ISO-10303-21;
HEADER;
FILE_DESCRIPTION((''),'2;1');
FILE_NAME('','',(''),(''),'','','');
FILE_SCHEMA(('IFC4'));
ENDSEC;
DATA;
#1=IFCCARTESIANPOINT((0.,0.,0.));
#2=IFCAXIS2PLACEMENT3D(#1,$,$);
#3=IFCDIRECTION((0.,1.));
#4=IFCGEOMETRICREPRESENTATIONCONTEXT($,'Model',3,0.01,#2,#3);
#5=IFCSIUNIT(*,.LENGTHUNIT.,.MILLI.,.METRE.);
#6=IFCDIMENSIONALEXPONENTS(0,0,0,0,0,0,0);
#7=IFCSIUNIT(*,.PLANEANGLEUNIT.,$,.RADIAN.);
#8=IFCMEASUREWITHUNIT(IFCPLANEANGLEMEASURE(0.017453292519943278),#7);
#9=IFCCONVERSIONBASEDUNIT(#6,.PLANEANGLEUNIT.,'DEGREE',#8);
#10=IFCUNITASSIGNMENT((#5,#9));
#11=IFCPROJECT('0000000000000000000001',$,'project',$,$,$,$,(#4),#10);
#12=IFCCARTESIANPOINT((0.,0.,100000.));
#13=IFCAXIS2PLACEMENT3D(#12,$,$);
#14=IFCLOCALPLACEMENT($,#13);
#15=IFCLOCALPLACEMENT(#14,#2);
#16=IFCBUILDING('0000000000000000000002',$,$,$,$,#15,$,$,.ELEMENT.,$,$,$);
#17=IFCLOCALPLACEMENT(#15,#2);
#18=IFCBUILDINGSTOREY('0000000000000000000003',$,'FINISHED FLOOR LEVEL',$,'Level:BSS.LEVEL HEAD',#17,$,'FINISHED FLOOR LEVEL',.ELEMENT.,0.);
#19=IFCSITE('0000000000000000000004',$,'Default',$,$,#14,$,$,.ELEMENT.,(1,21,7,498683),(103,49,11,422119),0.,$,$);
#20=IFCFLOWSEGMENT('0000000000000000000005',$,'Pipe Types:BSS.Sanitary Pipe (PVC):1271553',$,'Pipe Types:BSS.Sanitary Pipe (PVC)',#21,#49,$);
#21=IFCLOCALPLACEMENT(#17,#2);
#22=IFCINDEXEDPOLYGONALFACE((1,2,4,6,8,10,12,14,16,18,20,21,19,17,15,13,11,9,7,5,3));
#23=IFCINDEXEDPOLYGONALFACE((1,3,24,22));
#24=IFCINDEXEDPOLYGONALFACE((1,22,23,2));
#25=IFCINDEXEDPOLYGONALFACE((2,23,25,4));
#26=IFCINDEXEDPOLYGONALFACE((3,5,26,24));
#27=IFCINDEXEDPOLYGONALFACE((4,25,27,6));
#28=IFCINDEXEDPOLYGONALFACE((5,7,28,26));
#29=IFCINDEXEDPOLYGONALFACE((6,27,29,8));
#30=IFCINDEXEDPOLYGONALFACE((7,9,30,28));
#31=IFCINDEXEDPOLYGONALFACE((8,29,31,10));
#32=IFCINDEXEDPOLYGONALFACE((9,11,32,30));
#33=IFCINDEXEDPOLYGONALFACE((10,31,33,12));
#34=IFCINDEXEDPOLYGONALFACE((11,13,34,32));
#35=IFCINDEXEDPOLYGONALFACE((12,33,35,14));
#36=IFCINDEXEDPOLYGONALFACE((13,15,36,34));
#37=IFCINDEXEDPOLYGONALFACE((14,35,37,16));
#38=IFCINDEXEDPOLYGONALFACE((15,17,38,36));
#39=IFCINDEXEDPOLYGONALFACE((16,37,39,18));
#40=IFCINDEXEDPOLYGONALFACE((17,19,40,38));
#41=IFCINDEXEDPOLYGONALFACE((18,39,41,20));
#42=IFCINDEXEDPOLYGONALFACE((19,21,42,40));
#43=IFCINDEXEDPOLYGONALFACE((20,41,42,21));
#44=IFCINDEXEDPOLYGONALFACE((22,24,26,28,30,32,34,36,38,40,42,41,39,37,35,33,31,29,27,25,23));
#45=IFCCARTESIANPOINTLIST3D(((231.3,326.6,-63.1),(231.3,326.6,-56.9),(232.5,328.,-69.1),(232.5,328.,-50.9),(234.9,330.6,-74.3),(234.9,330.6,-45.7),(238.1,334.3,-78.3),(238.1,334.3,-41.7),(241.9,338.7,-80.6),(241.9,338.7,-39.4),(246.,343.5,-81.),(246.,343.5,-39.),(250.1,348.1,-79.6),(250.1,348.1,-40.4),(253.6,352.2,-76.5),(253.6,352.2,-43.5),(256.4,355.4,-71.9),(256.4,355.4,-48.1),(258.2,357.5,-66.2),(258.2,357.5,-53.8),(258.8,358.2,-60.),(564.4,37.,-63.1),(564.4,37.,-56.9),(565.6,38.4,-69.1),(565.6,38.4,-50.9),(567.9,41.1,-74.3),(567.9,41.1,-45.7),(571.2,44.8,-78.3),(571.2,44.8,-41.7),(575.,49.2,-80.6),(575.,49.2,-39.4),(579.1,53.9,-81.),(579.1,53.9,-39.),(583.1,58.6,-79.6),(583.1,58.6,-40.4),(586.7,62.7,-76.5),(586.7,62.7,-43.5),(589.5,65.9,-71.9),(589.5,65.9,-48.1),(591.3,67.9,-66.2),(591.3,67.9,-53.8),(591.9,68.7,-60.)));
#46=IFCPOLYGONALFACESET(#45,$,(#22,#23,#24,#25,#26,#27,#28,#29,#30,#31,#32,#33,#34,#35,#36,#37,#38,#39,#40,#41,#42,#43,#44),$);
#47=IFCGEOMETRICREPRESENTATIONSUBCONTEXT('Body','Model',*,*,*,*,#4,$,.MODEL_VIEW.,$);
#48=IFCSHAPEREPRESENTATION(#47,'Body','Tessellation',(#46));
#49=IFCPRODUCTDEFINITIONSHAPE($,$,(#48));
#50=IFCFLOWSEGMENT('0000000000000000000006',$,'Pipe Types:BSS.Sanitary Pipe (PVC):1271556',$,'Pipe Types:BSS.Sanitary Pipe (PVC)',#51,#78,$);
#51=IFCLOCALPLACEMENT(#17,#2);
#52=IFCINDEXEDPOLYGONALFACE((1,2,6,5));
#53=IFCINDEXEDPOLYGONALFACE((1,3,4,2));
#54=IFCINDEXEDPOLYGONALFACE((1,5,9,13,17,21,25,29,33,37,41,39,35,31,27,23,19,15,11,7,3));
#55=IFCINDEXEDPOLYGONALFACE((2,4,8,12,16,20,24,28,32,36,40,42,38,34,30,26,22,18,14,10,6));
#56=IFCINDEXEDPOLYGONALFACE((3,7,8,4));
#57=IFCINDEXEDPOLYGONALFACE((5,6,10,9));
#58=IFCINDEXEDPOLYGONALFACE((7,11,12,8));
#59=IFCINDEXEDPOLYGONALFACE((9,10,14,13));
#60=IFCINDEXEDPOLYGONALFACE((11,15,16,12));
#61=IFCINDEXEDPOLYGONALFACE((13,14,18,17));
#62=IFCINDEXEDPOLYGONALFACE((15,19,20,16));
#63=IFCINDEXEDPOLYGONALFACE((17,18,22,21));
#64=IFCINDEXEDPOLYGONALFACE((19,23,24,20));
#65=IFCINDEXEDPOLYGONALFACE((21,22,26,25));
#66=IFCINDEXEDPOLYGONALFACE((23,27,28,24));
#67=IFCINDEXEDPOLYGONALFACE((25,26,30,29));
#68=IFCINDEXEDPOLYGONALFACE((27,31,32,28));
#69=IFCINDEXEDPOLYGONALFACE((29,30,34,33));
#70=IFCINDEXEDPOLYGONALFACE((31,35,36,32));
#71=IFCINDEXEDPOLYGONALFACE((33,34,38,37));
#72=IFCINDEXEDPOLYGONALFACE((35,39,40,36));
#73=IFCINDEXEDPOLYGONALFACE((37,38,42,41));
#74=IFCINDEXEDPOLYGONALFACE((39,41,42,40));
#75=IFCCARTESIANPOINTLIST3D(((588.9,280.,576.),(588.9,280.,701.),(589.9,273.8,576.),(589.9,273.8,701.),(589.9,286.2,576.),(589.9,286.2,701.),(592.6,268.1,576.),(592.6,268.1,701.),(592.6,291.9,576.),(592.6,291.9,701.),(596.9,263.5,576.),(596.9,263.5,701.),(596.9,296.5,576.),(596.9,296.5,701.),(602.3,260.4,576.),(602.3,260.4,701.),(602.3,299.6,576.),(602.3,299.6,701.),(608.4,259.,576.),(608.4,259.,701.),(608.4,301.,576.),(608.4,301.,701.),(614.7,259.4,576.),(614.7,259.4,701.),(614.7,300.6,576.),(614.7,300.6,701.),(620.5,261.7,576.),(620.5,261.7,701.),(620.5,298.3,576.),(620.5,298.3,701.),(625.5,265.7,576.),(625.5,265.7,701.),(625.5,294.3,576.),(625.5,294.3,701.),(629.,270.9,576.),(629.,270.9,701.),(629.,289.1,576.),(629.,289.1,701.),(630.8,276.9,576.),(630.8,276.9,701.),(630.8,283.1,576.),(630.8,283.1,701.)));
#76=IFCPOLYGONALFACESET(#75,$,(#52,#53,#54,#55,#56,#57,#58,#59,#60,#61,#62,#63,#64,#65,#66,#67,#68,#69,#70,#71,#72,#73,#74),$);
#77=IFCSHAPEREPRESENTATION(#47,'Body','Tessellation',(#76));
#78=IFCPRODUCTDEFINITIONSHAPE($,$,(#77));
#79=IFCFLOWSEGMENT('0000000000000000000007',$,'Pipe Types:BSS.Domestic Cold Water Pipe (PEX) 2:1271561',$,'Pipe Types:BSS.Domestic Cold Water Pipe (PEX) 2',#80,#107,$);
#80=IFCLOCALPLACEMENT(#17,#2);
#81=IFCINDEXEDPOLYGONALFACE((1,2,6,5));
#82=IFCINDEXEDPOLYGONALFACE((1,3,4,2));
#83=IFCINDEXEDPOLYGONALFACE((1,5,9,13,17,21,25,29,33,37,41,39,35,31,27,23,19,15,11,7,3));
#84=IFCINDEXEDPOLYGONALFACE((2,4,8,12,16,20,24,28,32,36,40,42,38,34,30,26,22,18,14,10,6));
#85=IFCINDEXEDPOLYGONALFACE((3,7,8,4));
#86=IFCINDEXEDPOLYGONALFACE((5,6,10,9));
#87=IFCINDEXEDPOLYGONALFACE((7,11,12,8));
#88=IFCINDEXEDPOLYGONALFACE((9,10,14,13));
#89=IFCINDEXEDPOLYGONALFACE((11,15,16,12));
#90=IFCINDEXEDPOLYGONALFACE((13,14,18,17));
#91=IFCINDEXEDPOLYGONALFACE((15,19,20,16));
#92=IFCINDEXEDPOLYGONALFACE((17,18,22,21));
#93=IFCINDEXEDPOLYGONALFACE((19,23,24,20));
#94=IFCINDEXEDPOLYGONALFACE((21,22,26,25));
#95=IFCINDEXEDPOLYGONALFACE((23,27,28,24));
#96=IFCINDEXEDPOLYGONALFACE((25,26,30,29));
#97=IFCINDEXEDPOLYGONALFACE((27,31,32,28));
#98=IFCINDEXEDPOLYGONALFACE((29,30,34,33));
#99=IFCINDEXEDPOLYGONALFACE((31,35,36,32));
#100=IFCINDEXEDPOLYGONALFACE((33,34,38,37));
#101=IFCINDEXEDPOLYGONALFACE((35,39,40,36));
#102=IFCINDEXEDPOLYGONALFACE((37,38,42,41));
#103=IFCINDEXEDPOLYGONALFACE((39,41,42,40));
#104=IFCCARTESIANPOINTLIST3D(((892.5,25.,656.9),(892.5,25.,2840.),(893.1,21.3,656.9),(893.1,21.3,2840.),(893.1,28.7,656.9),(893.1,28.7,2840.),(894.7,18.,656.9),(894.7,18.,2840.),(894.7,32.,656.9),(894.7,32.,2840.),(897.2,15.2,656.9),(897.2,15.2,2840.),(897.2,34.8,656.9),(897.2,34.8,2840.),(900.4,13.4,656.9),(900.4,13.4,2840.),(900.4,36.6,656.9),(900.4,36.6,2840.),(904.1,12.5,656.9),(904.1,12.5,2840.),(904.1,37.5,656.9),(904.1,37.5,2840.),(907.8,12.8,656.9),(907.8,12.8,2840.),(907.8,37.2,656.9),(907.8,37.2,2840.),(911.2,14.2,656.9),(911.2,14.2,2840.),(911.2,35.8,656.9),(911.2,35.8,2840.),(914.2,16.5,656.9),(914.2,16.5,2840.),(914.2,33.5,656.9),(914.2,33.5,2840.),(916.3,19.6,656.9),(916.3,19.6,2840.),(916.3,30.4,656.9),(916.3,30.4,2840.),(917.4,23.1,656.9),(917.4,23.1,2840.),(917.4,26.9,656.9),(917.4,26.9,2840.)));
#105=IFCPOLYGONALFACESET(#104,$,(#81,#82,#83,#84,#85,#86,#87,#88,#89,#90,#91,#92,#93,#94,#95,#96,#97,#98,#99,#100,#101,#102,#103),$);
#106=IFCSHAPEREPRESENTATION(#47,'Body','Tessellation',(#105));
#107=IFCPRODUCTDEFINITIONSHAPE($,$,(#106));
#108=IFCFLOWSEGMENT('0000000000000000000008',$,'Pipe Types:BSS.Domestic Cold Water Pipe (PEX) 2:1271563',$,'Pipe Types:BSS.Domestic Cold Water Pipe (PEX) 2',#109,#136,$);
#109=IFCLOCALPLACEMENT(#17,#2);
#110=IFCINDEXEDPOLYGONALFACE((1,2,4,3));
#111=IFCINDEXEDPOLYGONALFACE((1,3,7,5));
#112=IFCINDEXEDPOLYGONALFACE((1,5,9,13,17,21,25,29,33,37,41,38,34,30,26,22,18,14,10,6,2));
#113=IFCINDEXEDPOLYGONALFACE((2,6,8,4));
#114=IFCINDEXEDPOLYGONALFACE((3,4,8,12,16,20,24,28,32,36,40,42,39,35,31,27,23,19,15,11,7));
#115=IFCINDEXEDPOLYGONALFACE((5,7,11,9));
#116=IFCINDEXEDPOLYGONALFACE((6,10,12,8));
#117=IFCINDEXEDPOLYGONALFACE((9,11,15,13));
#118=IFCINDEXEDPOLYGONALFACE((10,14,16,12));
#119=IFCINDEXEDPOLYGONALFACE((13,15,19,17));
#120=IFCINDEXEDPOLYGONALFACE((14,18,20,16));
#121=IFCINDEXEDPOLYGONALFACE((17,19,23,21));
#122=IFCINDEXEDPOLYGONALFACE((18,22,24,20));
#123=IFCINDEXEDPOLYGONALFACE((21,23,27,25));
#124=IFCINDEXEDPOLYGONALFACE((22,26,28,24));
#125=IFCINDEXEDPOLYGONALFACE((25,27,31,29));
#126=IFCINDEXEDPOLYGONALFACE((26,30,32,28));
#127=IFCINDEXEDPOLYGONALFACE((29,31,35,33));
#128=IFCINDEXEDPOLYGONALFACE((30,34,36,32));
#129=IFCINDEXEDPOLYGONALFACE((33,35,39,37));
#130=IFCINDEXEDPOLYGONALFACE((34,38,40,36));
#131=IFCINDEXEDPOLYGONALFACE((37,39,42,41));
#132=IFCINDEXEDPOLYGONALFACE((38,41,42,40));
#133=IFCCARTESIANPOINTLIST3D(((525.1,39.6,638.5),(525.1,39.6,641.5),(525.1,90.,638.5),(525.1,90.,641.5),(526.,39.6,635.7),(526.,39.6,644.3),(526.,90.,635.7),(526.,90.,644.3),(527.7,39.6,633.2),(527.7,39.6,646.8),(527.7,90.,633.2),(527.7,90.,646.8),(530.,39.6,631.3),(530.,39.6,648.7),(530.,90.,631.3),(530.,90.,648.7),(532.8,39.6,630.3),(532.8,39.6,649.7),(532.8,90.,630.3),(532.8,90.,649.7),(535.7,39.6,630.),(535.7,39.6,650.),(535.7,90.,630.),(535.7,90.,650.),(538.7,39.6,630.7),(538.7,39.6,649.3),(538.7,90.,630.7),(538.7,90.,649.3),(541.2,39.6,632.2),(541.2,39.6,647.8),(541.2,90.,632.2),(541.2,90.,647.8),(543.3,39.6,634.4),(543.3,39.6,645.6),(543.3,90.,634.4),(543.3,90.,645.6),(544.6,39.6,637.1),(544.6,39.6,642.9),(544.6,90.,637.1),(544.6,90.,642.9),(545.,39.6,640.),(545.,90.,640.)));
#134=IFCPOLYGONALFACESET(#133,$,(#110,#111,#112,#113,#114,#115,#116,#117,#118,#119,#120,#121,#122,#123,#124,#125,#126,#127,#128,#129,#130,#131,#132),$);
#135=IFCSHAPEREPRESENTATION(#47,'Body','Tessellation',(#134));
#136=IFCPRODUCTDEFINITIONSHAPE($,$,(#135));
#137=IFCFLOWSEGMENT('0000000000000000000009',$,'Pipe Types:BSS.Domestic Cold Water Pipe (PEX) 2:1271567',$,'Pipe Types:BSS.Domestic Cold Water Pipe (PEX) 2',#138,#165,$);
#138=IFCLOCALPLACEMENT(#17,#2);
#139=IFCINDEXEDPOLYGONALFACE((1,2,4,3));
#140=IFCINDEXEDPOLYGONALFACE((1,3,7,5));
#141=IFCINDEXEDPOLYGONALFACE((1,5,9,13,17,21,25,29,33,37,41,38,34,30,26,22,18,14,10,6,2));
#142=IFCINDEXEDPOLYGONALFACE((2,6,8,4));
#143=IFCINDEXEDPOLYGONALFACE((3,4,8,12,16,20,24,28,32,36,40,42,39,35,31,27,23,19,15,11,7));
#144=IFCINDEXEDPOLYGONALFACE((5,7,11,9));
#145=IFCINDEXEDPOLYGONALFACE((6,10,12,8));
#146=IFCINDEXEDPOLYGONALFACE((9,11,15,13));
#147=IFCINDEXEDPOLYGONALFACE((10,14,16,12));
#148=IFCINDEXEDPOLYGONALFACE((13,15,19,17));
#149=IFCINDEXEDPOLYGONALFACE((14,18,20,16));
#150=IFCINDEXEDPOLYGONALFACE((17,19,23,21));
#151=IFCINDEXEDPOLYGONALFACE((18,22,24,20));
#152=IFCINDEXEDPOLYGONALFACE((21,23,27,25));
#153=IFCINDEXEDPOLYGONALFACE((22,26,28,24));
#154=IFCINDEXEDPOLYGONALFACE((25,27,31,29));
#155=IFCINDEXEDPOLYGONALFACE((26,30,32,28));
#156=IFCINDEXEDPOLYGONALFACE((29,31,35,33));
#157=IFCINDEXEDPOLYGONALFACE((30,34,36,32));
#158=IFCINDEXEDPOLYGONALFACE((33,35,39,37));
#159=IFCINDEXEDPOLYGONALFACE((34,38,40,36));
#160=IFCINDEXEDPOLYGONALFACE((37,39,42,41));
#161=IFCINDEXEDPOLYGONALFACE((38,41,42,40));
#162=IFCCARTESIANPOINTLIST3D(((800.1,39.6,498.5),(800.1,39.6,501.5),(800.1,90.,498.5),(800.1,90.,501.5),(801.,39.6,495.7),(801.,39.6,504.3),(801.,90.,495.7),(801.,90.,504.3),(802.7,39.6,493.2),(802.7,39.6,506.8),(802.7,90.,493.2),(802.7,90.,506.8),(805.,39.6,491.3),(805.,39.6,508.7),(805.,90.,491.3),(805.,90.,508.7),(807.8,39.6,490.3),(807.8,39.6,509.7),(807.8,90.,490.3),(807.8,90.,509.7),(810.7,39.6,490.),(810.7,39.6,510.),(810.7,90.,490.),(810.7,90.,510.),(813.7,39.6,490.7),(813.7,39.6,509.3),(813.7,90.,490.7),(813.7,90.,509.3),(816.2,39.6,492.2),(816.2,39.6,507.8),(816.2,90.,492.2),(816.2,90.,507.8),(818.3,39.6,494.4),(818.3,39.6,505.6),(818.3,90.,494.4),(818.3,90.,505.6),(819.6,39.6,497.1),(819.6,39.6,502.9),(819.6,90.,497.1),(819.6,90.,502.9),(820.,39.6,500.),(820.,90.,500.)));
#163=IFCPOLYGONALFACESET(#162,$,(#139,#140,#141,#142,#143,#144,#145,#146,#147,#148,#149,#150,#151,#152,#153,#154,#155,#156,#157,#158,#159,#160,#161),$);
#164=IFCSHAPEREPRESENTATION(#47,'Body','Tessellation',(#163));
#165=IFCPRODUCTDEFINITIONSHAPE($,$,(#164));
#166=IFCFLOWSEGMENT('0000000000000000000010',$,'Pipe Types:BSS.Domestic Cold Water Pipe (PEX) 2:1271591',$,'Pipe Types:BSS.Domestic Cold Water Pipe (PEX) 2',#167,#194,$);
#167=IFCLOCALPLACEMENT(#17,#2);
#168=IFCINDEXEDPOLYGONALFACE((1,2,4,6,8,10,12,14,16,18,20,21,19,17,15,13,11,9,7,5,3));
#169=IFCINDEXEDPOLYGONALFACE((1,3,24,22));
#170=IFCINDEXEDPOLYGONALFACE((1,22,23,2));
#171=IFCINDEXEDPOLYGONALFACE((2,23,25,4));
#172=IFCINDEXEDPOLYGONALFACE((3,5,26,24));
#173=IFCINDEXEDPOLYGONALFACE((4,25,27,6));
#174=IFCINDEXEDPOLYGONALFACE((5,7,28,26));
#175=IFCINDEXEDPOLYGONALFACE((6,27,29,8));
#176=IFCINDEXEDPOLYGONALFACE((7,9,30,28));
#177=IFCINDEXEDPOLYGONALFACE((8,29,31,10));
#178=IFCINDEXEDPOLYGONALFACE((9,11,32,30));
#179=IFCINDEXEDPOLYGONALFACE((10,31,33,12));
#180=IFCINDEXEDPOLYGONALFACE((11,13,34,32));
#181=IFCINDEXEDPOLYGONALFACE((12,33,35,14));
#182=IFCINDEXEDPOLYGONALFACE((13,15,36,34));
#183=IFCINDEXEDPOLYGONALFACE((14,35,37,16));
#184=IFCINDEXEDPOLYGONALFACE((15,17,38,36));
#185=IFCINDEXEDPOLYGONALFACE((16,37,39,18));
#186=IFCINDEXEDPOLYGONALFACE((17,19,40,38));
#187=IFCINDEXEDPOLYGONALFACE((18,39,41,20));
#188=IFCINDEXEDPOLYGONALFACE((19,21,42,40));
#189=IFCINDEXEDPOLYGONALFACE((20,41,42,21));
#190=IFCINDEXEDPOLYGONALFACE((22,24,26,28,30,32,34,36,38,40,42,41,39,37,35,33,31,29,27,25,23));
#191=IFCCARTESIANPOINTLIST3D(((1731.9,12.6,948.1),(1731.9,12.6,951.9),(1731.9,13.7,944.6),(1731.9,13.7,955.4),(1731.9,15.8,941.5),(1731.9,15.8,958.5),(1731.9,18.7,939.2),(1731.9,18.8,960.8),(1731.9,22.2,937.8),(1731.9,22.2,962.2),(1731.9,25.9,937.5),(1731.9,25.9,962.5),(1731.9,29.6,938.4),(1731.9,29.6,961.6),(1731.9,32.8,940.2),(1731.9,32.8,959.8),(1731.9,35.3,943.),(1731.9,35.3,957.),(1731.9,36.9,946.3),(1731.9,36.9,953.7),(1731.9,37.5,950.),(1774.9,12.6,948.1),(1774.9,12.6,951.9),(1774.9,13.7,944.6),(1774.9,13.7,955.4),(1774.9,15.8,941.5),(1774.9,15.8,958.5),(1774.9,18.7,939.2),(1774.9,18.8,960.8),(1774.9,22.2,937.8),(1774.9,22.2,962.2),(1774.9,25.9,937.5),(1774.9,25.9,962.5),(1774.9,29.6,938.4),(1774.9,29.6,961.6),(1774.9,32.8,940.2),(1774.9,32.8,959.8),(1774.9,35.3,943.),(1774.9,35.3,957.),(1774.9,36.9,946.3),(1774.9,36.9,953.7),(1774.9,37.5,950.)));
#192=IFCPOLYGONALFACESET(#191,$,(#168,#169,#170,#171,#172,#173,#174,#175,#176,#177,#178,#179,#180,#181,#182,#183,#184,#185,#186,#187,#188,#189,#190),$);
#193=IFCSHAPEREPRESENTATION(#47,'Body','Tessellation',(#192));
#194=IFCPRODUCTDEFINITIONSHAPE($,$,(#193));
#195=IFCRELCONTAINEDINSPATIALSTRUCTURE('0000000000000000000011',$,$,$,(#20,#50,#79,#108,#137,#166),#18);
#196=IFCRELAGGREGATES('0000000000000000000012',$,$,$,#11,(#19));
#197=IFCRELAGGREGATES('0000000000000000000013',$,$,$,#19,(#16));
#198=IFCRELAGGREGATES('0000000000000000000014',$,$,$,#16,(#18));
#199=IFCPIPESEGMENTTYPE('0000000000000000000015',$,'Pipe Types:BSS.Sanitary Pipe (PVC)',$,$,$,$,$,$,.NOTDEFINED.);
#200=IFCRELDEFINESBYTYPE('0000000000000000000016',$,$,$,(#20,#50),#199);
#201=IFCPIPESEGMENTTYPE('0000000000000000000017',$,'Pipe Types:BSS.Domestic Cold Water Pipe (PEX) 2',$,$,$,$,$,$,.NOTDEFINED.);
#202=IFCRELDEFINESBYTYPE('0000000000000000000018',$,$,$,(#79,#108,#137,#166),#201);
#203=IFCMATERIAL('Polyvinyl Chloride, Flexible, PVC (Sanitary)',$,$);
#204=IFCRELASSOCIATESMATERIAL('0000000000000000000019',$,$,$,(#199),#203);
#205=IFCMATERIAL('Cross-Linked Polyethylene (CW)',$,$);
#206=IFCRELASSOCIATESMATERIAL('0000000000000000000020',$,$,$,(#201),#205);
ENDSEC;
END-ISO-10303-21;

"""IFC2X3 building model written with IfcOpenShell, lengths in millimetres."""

from ifc_helpers import new_model, entity, si_unit, converted_unit, direction, frame, frame_2d, origin, origin_2d_with_axis, place, context, subcontext, project, spatial, circle, extrude, material, type_object, element, save


model = new_model("IFC2X3")

# Units and contexts
model_context = context("Model", 3, precision=0.01, world=origin(), true_north=direction((0.0, 1.0)))
body_context = subcontext(model_context, "Body", "Model", "MODEL_VIEW")
ifc_project = project(units=[si_unit("LENGTHUNIT", "METRE", prefix="MILLI"), converted_unit("PLANEANGLEUNIT", "DEGREE", entity("IfcPlaneAngleMeasure", 0.017453292519943278), si_unit("PLANEANGLEUNIT", "RADIAN"), dimensions=[0, 0, 0, 0, 0, 0, 0])], contexts=[model_context])

# Site, building, storey
site_placement = place(None, frame((0.0, 0.0, 100000.0)))
site = spatial("IfcSite", under=ifc_project, at=site_placement, Name="Default", CompositionType="ELEMENT", RefLatitude=(1, 21, 7, 498683), RefLongitude=(103, 49, 11, 422119), RefElevation=0.0)
building_placement = place(site_placement, origin())
building = spatial("IfcBuilding", under=site, at=building_placement, CompositionType="ELEMENT")
storey_placement = place(building_placement, origin())
storey = spatial("IfcBuildingStorey", under=building, at=storey_placement, Name="FINISHED FLOOR LEVEL", ObjectType="Level:BSS.LEVEL HEAD", LongName="FINISHED FLOOR LEVEL", CompositionType="ELEMENT", Elevation=0.0)

# Flow segments
ifc_material_1 = material(Name="Polyvinyl Chloride, Flexible, PVC (Sanitary)")
pipe_segment_type_1 = type_object("IfcPipeSegmentType", Name="Pipe Types:BSS.Sanitary Pipe (PVC)", PredefinedType="NOTDEFINED", material=ifc_material_1)
flow_segment_1_placement = place(storey_placement, origin())
element("IfcFlowSegment", 1, at=flow_segment_1_placement, inside=storey, type_object=pipe_segment_type_1, Name="Pipe Types:BSS.Sanitary Pipe (PVC):1271553", ObjectType="Pipe Types:BSS.Sanitary Pipe (PVC)", context=body_context, shape_type="SweptSolid", body=[
    extrude(circle(Radius=21.1, at=frame_2d((0.0, 0.0), x_axis=(1.0, 0.0))), frame((245.0, 342.3, -60.0), z_axis=(0.75471, -0.656059, 0.0), x_axis=(0.656059, 0.75471, 0.0)), (0.0, 0.0, 1.0), 441.3),
])
flow_segment_2_placement = place(storey_placement, origin())
element("IfcFlowSegment", 2, at=flow_segment_2_placement, inside=storey, type_object=pipe_segment_type_1, Name="Pipe Types:BSS.Sanitary Pipe (PVC):1271556", ObjectType="Pipe Types:BSS.Sanitary Pipe (PVC)", context=body_context, shape_type="SweptSolid", body=[
    extrude(circle(Radius=21.1, at=frame_2d((0.0, 0.0), x_axis=(1.0, 0.0))), frame((610.0, 280.0, 576.0), z_axis=(0.0, 0.0, 1.0), x_axis=(-1.0, 0.0, 0.0)), (0.0, 0.0, 1.0), 125.0),
])
ifc_material_2 = material(Name="Cross-Linked Polyethylene (CW)")
pipe_segment_type_2 = type_object("IfcPipeSegmentType", Name="Pipe Types:BSS.Domestic Cold Water Pipe (PEX) 2", PredefinedType="NOTDEFINED", material=ifc_material_2)
flow_segment_3_placement = place(storey_placement, origin())
element("IfcFlowSegment", 3, at=flow_segment_3_placement, inside=storey, type_object=pipe_segment_type_2, Name="Pipe Types:BSS.Domestic Cold Water Pipe (PEX) 2:1271561", ObjectType="Pipe Types:BSS.Domestic Cold Water Pipe (PEX) 2", context=body_context, shape_type="SweptSolid", body=[
    extrude(circle(Radius=12.5, at=frame_2d((0.0, 0.0), x_axis=(1.0, 0.0))), frame((905.0, 25.0, 656.9), z_axis=(0.0, 0.0, 1.0), x_axis=(-1.0, 0.0, 0.0)), (0.0, 0.0, 1.0), 2183.1),
])
flow_segment_4_placement = place(storey_placement, origin())
element("IfcFlowSegment", 4, at=flow_segment_4_placement, inside=storey, type_object=pipe_segment_type_2, Name="Pipe Types:BSS.Domestic Cold Water Pipe (PEX) 2:1271563", ObjectType="Pipe Types:BSS.Domestic Cold Water Pipe (PEX) 2", context=body_context, shape_type="SweptSolid", body=[
    extrude(circle(Radius=10.0, at=origin_2d_with_axis()), frame((535.0, 39.6, 640.0), z_axis=(0.0, 1.0, 0.0), x_axis=(1.0, 0.0, 0.0)), (0.0, 0.0, 1.0), 50.4),
])
flow_segment_5_placement = place(storey_placement, origin())
element("IfcFlowSegment", 5, at=flow_segment_5_placement, inside=storey, type_object=pipe_segment_type_2, Name="Pipe Types:BSS.Domestic Cold Water Pipe (PEX) 2:1271567", ObjectType="Pipe Types:BSS.Domestic Cold Water Pipe (PEX) 2", context=body_context, shape_type="SweptSolid", body=[
    extrude(circle(Radius=10.0, at=frame_2d((0.0, 0.0), x_axis=(1.0, 0.0))), frame((810.0, 39.6, 500.0), z_axis=(0.0, 1.0, 0.0), x_axis=(1.0, 0.0, 0.0)), (0.0, 0.0, 1.0), 50.4),
])
flow_segment_6_placement = place(storey_placement, origin())
element("IfcFlowSegment", 6, at=flow_segment_6_placement, inside=storey, type_object=pipe_segment_type_2, Name="Pipe Types:BSS.Domestic Cold Water Pipe (PEX) 2:1271591", ObjectType="Pipe Types:BSS.Domestic Cold Water Pipe (PEX) 2", context=body_context, shape_type="SweptSolid", body=[
    extrude(circle(Radius=12.5, at=frame_2d((0.0, 0.0), x_axis=(1.0, 0.0))), frame((1731.9, 25.0, 950.0), z_axis=(1.0, 0.0, 0.0), x_axis=(0.0, 1.0, 0.0)), (0.0, 0.0, 1.0), 42.9),
])

save(model, "model.ifc")
